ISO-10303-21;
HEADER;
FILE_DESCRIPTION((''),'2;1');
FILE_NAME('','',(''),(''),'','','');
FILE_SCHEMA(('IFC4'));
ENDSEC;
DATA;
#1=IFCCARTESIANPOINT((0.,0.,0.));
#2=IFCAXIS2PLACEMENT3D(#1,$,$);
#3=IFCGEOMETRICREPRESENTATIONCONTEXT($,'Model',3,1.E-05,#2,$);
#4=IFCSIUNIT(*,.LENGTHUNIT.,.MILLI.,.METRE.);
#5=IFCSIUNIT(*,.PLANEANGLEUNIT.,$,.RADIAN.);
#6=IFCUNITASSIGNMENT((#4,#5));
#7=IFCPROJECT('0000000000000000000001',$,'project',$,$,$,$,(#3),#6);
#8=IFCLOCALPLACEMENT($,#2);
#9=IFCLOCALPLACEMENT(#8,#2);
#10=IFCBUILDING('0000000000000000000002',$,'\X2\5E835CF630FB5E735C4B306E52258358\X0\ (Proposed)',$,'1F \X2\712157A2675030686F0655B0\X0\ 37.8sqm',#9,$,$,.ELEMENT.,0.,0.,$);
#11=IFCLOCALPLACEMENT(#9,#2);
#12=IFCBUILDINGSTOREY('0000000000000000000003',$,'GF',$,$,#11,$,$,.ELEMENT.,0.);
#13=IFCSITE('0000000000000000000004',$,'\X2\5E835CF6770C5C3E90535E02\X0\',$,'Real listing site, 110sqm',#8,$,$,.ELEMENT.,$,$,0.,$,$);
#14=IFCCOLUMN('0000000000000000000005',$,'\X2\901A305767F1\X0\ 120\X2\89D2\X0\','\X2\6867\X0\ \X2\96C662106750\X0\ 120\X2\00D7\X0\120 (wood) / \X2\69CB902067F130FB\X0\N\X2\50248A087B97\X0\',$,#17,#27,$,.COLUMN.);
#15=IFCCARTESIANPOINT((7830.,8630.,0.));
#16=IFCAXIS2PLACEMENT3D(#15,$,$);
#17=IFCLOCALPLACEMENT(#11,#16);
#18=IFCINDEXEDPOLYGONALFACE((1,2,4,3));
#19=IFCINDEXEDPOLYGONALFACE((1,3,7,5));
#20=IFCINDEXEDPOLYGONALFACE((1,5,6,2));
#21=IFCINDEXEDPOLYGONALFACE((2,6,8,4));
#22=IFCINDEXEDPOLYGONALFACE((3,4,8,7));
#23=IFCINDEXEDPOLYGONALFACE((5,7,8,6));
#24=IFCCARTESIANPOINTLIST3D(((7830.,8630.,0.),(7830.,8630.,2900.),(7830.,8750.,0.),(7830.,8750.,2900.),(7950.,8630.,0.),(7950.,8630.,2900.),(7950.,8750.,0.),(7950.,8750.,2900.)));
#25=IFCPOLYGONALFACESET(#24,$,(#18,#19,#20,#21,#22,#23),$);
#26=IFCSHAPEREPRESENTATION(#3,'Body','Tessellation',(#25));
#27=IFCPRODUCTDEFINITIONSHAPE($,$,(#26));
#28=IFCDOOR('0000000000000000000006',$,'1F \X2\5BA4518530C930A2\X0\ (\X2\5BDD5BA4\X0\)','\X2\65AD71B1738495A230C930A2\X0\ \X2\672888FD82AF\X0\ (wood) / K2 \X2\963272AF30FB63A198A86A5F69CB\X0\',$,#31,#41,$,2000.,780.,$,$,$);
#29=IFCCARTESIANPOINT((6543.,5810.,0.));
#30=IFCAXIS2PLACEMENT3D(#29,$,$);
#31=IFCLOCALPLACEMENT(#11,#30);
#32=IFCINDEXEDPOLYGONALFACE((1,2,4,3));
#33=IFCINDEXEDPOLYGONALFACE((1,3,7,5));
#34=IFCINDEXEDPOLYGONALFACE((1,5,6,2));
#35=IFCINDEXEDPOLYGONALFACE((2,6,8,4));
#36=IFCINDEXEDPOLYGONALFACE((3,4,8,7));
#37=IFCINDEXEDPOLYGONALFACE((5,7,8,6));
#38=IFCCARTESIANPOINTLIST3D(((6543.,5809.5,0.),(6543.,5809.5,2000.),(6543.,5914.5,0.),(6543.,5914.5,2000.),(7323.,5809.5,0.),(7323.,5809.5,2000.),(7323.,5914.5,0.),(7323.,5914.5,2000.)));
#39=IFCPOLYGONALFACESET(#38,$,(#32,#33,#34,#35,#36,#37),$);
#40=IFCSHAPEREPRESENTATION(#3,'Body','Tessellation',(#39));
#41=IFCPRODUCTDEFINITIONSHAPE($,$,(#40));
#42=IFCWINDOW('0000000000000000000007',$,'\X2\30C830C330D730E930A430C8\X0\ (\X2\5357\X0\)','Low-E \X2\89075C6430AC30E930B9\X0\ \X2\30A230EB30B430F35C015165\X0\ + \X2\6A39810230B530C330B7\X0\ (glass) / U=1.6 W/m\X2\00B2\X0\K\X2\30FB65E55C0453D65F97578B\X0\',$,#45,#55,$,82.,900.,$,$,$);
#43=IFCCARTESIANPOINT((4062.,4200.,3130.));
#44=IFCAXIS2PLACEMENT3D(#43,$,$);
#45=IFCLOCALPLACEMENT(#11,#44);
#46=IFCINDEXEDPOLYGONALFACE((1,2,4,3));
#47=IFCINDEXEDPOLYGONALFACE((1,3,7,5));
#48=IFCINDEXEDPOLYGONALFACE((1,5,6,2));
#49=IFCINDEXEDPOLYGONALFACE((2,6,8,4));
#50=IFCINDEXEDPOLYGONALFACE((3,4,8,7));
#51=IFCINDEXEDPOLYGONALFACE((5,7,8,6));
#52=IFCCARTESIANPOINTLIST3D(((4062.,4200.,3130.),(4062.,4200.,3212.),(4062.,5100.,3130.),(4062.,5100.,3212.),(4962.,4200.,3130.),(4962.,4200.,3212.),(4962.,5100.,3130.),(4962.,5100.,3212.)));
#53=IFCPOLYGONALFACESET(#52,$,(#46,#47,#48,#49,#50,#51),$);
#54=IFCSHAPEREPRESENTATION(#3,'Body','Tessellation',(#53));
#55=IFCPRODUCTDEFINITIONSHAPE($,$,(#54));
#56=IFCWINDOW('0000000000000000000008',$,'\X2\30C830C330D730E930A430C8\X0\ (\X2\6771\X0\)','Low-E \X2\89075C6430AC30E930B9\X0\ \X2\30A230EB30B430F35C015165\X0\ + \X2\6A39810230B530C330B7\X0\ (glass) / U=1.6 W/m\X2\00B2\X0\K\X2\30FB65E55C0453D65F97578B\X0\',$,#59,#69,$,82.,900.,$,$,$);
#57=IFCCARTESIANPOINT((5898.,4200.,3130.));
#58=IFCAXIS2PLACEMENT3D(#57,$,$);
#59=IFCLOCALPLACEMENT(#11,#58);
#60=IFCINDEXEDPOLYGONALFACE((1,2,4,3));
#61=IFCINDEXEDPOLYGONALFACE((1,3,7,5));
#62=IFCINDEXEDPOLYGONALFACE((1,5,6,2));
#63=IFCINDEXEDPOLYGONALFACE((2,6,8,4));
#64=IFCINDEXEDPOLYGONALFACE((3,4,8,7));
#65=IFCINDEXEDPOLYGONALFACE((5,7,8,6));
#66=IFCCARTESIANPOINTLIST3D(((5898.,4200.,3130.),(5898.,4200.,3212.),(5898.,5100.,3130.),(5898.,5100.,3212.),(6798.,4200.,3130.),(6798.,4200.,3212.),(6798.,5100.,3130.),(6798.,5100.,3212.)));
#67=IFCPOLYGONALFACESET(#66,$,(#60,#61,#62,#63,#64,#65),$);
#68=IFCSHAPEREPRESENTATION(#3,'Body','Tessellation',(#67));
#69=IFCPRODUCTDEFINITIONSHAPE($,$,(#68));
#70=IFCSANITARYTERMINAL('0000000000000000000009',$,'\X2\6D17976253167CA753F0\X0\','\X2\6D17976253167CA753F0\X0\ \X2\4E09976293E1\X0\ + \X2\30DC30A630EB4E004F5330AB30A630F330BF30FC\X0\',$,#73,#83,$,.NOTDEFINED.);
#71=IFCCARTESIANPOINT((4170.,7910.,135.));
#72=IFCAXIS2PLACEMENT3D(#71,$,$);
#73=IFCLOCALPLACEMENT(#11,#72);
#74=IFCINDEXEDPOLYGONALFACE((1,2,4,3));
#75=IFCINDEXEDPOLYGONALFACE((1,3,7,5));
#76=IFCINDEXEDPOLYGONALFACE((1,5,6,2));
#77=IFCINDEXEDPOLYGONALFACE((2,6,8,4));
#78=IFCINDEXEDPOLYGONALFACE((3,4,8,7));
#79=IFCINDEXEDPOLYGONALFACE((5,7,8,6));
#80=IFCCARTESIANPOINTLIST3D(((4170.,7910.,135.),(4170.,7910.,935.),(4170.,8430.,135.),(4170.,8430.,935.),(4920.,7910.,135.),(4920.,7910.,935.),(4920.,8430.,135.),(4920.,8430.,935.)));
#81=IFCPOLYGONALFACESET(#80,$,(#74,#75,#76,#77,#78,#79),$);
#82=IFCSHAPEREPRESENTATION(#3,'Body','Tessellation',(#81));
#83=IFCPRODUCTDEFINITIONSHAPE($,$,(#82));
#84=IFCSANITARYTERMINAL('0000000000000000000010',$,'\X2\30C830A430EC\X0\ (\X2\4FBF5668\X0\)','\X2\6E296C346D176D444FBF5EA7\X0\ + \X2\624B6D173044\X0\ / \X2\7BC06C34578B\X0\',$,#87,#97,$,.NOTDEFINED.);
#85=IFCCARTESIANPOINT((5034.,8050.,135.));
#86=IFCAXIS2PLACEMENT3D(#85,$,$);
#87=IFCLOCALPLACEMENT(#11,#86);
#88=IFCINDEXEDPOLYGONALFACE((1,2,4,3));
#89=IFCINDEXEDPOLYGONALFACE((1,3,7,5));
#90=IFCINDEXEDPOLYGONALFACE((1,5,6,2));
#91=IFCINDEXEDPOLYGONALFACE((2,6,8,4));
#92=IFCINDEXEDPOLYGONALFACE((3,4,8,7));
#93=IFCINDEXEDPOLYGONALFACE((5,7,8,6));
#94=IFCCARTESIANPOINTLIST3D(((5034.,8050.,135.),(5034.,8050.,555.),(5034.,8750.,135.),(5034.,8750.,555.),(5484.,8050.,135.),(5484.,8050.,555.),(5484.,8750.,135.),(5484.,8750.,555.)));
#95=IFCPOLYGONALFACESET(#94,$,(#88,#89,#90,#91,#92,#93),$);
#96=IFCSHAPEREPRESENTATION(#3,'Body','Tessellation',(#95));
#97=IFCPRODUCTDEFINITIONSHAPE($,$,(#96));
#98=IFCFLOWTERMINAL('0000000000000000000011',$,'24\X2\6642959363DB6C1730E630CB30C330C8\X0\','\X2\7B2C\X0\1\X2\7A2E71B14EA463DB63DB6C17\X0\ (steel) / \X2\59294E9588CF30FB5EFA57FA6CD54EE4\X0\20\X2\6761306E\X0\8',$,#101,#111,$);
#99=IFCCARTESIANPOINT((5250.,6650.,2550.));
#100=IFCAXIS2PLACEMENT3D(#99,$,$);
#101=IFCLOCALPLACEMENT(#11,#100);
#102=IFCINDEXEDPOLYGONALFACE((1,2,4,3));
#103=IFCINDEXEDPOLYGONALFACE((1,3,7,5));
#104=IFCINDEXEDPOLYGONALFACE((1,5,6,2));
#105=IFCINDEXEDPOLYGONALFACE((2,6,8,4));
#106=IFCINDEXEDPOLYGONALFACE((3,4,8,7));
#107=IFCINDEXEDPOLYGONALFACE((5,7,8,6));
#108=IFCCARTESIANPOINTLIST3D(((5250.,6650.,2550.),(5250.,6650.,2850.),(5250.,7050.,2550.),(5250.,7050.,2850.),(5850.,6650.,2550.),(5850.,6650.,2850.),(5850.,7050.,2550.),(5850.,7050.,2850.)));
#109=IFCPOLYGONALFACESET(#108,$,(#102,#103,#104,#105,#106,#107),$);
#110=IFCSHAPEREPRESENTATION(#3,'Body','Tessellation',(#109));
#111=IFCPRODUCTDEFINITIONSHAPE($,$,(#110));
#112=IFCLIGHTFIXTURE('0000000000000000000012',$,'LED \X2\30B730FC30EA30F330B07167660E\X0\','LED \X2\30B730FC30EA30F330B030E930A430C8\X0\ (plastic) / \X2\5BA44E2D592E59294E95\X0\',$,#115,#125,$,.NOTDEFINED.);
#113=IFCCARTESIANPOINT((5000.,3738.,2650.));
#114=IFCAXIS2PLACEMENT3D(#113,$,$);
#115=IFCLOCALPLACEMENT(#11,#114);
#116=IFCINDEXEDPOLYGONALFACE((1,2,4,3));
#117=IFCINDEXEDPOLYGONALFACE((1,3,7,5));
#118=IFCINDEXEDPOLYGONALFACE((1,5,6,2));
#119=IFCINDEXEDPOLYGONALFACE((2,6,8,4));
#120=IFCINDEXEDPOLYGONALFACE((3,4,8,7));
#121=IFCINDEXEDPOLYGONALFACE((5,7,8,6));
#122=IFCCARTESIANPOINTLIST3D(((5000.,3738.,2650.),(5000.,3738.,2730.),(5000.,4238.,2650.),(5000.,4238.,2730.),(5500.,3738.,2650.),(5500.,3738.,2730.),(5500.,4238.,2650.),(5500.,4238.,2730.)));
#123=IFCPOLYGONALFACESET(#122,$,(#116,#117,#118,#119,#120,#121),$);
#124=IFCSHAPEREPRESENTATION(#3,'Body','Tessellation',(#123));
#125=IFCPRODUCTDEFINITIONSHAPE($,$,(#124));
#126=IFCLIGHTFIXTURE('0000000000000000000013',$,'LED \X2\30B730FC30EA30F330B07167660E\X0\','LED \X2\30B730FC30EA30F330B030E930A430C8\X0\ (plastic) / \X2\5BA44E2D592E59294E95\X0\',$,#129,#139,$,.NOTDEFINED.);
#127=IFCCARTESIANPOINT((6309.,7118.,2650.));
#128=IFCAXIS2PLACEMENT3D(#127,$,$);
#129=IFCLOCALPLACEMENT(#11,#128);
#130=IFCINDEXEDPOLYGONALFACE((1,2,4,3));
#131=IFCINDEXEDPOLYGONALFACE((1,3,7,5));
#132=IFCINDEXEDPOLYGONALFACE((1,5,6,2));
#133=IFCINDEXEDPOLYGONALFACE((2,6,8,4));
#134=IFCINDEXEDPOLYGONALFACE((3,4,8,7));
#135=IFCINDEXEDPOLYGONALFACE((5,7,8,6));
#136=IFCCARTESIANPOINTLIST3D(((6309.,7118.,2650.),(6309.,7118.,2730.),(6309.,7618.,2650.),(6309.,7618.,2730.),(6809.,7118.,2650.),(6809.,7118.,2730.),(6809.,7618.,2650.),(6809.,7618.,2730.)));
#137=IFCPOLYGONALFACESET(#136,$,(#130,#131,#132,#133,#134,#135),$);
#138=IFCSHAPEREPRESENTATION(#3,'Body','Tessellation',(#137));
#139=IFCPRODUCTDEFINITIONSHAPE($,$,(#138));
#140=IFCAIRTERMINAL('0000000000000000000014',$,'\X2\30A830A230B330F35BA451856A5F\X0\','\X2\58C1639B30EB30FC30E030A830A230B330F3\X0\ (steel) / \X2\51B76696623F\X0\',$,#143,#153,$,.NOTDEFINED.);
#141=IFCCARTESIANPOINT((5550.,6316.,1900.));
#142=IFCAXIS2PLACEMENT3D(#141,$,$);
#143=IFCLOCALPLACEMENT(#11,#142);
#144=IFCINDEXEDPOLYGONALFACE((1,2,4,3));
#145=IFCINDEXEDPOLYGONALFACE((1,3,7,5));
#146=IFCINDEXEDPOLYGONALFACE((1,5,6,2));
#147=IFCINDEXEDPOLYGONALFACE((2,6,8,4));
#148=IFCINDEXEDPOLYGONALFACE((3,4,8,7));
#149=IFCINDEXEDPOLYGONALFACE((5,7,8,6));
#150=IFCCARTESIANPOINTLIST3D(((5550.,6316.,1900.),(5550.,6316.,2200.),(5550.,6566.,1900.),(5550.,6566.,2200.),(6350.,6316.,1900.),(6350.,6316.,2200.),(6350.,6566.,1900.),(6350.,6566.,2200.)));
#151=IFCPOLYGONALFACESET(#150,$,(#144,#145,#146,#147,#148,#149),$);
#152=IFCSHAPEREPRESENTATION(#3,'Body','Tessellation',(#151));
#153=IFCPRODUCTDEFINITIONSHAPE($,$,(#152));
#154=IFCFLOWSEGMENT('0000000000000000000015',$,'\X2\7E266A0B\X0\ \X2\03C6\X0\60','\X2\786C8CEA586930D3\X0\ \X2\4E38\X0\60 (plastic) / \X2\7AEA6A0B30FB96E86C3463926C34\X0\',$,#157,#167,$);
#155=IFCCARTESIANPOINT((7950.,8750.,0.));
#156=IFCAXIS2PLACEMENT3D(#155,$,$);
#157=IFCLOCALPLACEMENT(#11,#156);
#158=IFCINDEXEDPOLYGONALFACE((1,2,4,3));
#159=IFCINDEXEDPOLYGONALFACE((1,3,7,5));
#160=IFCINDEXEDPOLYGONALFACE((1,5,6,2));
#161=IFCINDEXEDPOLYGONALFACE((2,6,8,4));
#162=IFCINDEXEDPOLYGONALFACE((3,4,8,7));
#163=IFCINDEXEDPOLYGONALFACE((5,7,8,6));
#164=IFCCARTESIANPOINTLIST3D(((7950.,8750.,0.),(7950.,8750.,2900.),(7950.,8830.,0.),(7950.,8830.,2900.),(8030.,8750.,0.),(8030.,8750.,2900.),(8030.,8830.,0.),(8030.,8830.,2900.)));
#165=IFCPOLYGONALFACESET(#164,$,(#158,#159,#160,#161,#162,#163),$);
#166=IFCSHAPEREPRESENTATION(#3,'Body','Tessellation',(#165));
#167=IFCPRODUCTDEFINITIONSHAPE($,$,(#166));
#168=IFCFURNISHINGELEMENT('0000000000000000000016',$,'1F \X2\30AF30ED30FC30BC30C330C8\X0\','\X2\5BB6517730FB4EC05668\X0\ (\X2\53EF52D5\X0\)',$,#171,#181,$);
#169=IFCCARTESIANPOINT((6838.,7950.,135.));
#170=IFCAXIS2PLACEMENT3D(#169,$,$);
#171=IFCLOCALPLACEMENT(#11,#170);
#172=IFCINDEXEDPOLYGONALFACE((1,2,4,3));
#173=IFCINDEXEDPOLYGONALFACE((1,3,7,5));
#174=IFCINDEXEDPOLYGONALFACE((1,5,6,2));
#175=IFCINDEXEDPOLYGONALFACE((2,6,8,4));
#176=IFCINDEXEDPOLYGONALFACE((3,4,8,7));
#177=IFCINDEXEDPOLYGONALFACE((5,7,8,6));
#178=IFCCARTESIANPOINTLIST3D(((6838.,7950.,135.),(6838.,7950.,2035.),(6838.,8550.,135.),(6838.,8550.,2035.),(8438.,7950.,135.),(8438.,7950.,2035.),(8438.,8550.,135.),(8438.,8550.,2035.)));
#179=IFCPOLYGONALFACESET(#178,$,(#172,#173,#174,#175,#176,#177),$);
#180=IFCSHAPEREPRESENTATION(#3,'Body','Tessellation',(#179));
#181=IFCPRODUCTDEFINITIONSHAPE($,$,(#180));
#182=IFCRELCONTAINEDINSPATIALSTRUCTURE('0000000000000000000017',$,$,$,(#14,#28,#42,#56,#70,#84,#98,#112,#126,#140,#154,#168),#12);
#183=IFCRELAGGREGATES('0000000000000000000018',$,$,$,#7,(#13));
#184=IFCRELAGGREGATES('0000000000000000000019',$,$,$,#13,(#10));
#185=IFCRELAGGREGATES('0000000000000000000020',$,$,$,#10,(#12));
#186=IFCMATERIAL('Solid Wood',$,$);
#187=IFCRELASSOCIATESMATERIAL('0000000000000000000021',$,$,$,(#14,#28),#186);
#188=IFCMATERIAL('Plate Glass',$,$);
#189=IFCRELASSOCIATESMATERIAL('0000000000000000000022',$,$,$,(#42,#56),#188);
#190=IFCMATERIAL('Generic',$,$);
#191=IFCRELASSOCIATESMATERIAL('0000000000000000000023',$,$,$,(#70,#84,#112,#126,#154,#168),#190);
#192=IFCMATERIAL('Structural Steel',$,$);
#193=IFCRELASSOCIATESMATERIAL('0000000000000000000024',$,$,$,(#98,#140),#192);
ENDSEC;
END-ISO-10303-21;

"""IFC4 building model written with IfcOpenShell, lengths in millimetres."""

from ifc_helpers import new_model, si_unit, frame, frame_2d, origin, place, context, project, spatial, rectangle, extrude, material, element, save


model = new_model("IFC4")

# Units and contexts
model_context = context("Model", 3, precision=1e-05, world=origin())
ifc_project = project(units=[si_unit("LENGTHUNIT", "METRE", prefix="MILLI"), si_unit("PLANEANGLEUNIT", "RADIAN")], contexts=[model_context])

# Site, building, storey
site_placement = place(None, origin())
site = spatial("IfcSite", under=ifc_project, at=site_placement, Name="広島県尾道市", ObjectType="Real listing site, 110sqm", CompositionType="ELEMENT", RefElevation=0.0)
building_placement = place(site_placement, origin())
building = spatial("IfcBuilding", under=site, at=building_placement, Name="広島・平屋の別荘 (Proposed)", ObjectType="1F 無垢材と漆喰 37.8sqm", CompositionType="ELEMENT", ElevationOfRefHeight=0.0, ElevationOfTerrain=0.0)
storey_placement = place(building_placement, origin())
storey = spatial("IfcBuildingStorey", under=building, at=storey_placement, Name="GF", CompositionType="ELEMENT", Elevation=0.0)

# Column
ifc_material_1 = material(Name="Solid Wood")
column_1_placement = place(storey_placement, frame((7830.0, 8630.0, 0.0)))
element("IfcColumn", 1, at=column_1_placement, inside=storey, material=ifc_material_1, Name="通し柱 120角", Description="桧 集成材 120×120 (wood) / 構造柱・N値計算", PredefinedType="COLUMN", context=model_context, shape_type="SweptSolid", body=[
    extrude(rectangle(XDim=120.0, YDim=120.0, at=frame_2d((60.0, 60.0))), frame((7830.0, 8630.0, 0.0)), (0.0, 0.0, 1.0), 2900.0),
])

# Door
door_placement = place(storey_placement, frame((6543.0, 5810.0, 0.0)))
element("IfcDoor", 2, at=door_placement, inside=storey, material=ifc_material_1, Name="1F 室内ドア (寝室)", Description="断熱玄関ドア 木製芯 (wood) / K2 防犯・採風機構", OverallHeight=2000.0, OverallWidth=780.0, context=model_context, shape_type="SweptSolid", body=[
    extrude(rectangle(XDim=780.0, YDim=105.0, at=frame_2d((390.0, 52.0))), frame((6543.0, 5810.0, 0.0)), (0.0, 0.0, 1.0), 2000.0),
])

# Windows
ifc_material_2 = material(Name="Plate Glass")
window_1_placement = place(storey_placement, frame((4062.0, 4200.0, 3130.0)))
element("IfcWindow", 3, at=window_1_placement, inside=storey, material=ifc_material_2, Name="トップライト (南)", Description="Low-E 複層ガラス アルゴン封入 + 樹脂サッシ (glass) / U=1.6 W/m²K・日射取得型", OverallHeight=82.0, OverallWidth=900.0, context=model_context, shape_type="SweptSolid", body=[
    extrude(rectangle(XDim=900.0, YDim=900.0, at=frame_2d((450.0, 450.0))), frame((4062.0, 4200.0, 3130.0)), (0.0, 0.0, 1.0), 82.0),
])
window_2_placement = place(storey_placement, frame((5898.0, 4200.0, 3130.0)))
element("IfcWindow", 4, at=window_2_placement, inside=storey, material=ifc_material_2, Name="トップライト (東)", Description="Low-E 複層ガラス アルゴン封入 + 樹脂サッシ (glass) / U=1.6 W/m²K・日射取得型", OverallHeight=82.0, OverallWidth=900.0, context=model_context, shape_type="SweptSolid", body=[
    extrude(rectangle(XDim=900.0, YDim=900.0, at=frame_2d((450.0, 450.0))), frame((5898.0, 4200.0, 3130.0)), (0.0, 0.0, 1.0), 82.0),
])

# Sanitary terminals
ifc_material_3 = material(Name="Generic")
sanitary_terminal_1_placement = place(storey_placement, frame((4170.0, 7910.0, 135.0)))
element("IfcSanitaryTerminal", 5, at=sanitary_terminal_1_placement, inside=storey, material=ifc_material_3, Name="洗面化粧台", Description="洗面化粧台 三面鏡 + ボウル一体カウンター", PredefinedType="NOTDEFINED", context=model_context, shape_type="SweptSolid", body=[
    extrude(rectangle(XDim=750.0, YDim=520.0, at=frame_2d((375.0, 260.0))), frame((4170.0, 7910.0, 135.0)), (0.0, 0.0, 1.0), 800.0),
])
sanitary_terminal_2_placement = place(storey_placement, frame((5034.0, 8050.0, 135.0)))
element("IfcSanitaryTerminal", 6, at=sanitary_terminal_2_placement, inside=storey, material=ifc_material_3, Name="トイレ (便器)", Description="温水洗浄便座 + 手洗い / 節水型", PredefinedType="NOTDEFINED", context=model_context, shape_type="SweptSolid", body=[
    extrude(rectangle(XDim=450.0, YDim=700.0, at=frame_2d((225.0, 350.0))), frame((5034.0, 8050.0, 135.0)), (0.0, 0.0, 1.0), 420.0),
])

# Flow terminal
ifc_material_4 = material(Name="Structural Steel")
flow_terminal_placement = place(storey_placement, frame((5250.0, 6650.0, 2550.0)))
element("IfcFlowTerminal", 7, at=flow_terminal_placement, inside=storey, material=ifc_material_4, Name="24時間換気ユニット", Description="第1種熱交換換気 (steel) / 天井裏・建基法令20条の8", context=model_context, shape_type="SweptSolid", body=[
    extrude(rectangle(XDim=600.0, YDim=400.0, at=frame_2d((300.0, 200.0))), frame((5250.0, 6650.0, 2550.0)), (0.0, 0.0, 1.0), 300.0),
])

# Light fixtures
light_fixture_1_placement = place(storey_placement, frame((5000.0, 3738.0, 2650.0)))
element("IfcLightFixture", 8, at=light_fixture_1_placement, inside=storey, material=ifc_material_3, Name="LED シーリング照明", Description="LED シーリングライト (plastic) / 室中央天井", PredefinedType="NOTDEFINED", context=model_context, shape_type="SweptSolid", body=[
    extrude(rectangle(XDim=500.0, YDim=500.0, at=frame_2d((250.0, 250.0))), frame((5000.0, 3738.0, 2650.0)), (0.0, 0.0, 1.0), 80.0),
])
light_fixture_2_placement = place(storey_placement, frame((6309.0, 7118.0, 2650.0)))
element("IfcLightFixture", 9, at=light_fixture_2_placement, inside=storey, material=ifc_material_3, Name="LED シーリング照明", Description="LED シーリングライト (plastic) / 室中央天井", PredefinedType="NOTDEFINED", context=model_context, shape_type="SweptSolid", body=[
    extrude(rectangle(XDim=500.0, YDim=500.0, at=frame_2d((250.0, 250.0))), frame((6309.0, 7118.0, 2650.0)), (0.0, 0.0, 1.0), 80.0),
])

# Air terminal
air_terminal_placement = place(storey_placement, frame((5550.0, 6316.0, 1900.0)))
element("IfcAirTerminal", 10, at=air_terminal_placement, inside=storey, material=ifc_material_4, Name="エアコン室内機", Description="壁掛ルームエアコン (steel) / 冷暖房", PredefinedType="NOTDEFINED", context=model_context, shape_type="SweptSolid", body=[
    extrude(rectangle(XDim=800.0, YDim=250.0, at=frame_2d((400.0, 125.0))), frame((5550.0, 6316.0, 1900.0)), (0.0, 0.0, 1.0), 300.0),
])

# Flow segment
flow_segment_placement = place(storey_placement, frame((7950.0, 8750.0, 0.0)))
element("IfcFlowSegment", 11, at=flow_segment_placement, inside=storey, material=ifc_material_3, Name="縦樋 φ60", Description="硬質塩ビ 丸60 (plastic) / 竪樋・雨水排水", context=model_context, shape_type="SweptSolid", body=[
    extrude(rectangle(XDim=80.0, YDim=80.0, at=frame_2d((40.0, 40.0))), frame((7950.0, 8750.0, 0.0)), (0.0, 0.0, 1.0), 2900.0),
])

# Furnishing element
furnishing_placement = place(storey_placement, frame((6838.0, 7950.0, 135.0)))
element("IfcFurnishingElement", 12, at=furnishing_placement, inside=storey, material=ifc_material_3, Name="1F クローゼット", Description="家具・什器 (可動)", context=model_context, shape_type="SweptSolid", body=[
    extrude(rectangle(XDim=1600.0, YDim=600.0, at=frame_2d((800.0, 300.0))), frame((6838.0, 7950.0, 135.0)), (0.0, 0.0, 1.0), 1900.0),
])

save(model, "model.ifc")
